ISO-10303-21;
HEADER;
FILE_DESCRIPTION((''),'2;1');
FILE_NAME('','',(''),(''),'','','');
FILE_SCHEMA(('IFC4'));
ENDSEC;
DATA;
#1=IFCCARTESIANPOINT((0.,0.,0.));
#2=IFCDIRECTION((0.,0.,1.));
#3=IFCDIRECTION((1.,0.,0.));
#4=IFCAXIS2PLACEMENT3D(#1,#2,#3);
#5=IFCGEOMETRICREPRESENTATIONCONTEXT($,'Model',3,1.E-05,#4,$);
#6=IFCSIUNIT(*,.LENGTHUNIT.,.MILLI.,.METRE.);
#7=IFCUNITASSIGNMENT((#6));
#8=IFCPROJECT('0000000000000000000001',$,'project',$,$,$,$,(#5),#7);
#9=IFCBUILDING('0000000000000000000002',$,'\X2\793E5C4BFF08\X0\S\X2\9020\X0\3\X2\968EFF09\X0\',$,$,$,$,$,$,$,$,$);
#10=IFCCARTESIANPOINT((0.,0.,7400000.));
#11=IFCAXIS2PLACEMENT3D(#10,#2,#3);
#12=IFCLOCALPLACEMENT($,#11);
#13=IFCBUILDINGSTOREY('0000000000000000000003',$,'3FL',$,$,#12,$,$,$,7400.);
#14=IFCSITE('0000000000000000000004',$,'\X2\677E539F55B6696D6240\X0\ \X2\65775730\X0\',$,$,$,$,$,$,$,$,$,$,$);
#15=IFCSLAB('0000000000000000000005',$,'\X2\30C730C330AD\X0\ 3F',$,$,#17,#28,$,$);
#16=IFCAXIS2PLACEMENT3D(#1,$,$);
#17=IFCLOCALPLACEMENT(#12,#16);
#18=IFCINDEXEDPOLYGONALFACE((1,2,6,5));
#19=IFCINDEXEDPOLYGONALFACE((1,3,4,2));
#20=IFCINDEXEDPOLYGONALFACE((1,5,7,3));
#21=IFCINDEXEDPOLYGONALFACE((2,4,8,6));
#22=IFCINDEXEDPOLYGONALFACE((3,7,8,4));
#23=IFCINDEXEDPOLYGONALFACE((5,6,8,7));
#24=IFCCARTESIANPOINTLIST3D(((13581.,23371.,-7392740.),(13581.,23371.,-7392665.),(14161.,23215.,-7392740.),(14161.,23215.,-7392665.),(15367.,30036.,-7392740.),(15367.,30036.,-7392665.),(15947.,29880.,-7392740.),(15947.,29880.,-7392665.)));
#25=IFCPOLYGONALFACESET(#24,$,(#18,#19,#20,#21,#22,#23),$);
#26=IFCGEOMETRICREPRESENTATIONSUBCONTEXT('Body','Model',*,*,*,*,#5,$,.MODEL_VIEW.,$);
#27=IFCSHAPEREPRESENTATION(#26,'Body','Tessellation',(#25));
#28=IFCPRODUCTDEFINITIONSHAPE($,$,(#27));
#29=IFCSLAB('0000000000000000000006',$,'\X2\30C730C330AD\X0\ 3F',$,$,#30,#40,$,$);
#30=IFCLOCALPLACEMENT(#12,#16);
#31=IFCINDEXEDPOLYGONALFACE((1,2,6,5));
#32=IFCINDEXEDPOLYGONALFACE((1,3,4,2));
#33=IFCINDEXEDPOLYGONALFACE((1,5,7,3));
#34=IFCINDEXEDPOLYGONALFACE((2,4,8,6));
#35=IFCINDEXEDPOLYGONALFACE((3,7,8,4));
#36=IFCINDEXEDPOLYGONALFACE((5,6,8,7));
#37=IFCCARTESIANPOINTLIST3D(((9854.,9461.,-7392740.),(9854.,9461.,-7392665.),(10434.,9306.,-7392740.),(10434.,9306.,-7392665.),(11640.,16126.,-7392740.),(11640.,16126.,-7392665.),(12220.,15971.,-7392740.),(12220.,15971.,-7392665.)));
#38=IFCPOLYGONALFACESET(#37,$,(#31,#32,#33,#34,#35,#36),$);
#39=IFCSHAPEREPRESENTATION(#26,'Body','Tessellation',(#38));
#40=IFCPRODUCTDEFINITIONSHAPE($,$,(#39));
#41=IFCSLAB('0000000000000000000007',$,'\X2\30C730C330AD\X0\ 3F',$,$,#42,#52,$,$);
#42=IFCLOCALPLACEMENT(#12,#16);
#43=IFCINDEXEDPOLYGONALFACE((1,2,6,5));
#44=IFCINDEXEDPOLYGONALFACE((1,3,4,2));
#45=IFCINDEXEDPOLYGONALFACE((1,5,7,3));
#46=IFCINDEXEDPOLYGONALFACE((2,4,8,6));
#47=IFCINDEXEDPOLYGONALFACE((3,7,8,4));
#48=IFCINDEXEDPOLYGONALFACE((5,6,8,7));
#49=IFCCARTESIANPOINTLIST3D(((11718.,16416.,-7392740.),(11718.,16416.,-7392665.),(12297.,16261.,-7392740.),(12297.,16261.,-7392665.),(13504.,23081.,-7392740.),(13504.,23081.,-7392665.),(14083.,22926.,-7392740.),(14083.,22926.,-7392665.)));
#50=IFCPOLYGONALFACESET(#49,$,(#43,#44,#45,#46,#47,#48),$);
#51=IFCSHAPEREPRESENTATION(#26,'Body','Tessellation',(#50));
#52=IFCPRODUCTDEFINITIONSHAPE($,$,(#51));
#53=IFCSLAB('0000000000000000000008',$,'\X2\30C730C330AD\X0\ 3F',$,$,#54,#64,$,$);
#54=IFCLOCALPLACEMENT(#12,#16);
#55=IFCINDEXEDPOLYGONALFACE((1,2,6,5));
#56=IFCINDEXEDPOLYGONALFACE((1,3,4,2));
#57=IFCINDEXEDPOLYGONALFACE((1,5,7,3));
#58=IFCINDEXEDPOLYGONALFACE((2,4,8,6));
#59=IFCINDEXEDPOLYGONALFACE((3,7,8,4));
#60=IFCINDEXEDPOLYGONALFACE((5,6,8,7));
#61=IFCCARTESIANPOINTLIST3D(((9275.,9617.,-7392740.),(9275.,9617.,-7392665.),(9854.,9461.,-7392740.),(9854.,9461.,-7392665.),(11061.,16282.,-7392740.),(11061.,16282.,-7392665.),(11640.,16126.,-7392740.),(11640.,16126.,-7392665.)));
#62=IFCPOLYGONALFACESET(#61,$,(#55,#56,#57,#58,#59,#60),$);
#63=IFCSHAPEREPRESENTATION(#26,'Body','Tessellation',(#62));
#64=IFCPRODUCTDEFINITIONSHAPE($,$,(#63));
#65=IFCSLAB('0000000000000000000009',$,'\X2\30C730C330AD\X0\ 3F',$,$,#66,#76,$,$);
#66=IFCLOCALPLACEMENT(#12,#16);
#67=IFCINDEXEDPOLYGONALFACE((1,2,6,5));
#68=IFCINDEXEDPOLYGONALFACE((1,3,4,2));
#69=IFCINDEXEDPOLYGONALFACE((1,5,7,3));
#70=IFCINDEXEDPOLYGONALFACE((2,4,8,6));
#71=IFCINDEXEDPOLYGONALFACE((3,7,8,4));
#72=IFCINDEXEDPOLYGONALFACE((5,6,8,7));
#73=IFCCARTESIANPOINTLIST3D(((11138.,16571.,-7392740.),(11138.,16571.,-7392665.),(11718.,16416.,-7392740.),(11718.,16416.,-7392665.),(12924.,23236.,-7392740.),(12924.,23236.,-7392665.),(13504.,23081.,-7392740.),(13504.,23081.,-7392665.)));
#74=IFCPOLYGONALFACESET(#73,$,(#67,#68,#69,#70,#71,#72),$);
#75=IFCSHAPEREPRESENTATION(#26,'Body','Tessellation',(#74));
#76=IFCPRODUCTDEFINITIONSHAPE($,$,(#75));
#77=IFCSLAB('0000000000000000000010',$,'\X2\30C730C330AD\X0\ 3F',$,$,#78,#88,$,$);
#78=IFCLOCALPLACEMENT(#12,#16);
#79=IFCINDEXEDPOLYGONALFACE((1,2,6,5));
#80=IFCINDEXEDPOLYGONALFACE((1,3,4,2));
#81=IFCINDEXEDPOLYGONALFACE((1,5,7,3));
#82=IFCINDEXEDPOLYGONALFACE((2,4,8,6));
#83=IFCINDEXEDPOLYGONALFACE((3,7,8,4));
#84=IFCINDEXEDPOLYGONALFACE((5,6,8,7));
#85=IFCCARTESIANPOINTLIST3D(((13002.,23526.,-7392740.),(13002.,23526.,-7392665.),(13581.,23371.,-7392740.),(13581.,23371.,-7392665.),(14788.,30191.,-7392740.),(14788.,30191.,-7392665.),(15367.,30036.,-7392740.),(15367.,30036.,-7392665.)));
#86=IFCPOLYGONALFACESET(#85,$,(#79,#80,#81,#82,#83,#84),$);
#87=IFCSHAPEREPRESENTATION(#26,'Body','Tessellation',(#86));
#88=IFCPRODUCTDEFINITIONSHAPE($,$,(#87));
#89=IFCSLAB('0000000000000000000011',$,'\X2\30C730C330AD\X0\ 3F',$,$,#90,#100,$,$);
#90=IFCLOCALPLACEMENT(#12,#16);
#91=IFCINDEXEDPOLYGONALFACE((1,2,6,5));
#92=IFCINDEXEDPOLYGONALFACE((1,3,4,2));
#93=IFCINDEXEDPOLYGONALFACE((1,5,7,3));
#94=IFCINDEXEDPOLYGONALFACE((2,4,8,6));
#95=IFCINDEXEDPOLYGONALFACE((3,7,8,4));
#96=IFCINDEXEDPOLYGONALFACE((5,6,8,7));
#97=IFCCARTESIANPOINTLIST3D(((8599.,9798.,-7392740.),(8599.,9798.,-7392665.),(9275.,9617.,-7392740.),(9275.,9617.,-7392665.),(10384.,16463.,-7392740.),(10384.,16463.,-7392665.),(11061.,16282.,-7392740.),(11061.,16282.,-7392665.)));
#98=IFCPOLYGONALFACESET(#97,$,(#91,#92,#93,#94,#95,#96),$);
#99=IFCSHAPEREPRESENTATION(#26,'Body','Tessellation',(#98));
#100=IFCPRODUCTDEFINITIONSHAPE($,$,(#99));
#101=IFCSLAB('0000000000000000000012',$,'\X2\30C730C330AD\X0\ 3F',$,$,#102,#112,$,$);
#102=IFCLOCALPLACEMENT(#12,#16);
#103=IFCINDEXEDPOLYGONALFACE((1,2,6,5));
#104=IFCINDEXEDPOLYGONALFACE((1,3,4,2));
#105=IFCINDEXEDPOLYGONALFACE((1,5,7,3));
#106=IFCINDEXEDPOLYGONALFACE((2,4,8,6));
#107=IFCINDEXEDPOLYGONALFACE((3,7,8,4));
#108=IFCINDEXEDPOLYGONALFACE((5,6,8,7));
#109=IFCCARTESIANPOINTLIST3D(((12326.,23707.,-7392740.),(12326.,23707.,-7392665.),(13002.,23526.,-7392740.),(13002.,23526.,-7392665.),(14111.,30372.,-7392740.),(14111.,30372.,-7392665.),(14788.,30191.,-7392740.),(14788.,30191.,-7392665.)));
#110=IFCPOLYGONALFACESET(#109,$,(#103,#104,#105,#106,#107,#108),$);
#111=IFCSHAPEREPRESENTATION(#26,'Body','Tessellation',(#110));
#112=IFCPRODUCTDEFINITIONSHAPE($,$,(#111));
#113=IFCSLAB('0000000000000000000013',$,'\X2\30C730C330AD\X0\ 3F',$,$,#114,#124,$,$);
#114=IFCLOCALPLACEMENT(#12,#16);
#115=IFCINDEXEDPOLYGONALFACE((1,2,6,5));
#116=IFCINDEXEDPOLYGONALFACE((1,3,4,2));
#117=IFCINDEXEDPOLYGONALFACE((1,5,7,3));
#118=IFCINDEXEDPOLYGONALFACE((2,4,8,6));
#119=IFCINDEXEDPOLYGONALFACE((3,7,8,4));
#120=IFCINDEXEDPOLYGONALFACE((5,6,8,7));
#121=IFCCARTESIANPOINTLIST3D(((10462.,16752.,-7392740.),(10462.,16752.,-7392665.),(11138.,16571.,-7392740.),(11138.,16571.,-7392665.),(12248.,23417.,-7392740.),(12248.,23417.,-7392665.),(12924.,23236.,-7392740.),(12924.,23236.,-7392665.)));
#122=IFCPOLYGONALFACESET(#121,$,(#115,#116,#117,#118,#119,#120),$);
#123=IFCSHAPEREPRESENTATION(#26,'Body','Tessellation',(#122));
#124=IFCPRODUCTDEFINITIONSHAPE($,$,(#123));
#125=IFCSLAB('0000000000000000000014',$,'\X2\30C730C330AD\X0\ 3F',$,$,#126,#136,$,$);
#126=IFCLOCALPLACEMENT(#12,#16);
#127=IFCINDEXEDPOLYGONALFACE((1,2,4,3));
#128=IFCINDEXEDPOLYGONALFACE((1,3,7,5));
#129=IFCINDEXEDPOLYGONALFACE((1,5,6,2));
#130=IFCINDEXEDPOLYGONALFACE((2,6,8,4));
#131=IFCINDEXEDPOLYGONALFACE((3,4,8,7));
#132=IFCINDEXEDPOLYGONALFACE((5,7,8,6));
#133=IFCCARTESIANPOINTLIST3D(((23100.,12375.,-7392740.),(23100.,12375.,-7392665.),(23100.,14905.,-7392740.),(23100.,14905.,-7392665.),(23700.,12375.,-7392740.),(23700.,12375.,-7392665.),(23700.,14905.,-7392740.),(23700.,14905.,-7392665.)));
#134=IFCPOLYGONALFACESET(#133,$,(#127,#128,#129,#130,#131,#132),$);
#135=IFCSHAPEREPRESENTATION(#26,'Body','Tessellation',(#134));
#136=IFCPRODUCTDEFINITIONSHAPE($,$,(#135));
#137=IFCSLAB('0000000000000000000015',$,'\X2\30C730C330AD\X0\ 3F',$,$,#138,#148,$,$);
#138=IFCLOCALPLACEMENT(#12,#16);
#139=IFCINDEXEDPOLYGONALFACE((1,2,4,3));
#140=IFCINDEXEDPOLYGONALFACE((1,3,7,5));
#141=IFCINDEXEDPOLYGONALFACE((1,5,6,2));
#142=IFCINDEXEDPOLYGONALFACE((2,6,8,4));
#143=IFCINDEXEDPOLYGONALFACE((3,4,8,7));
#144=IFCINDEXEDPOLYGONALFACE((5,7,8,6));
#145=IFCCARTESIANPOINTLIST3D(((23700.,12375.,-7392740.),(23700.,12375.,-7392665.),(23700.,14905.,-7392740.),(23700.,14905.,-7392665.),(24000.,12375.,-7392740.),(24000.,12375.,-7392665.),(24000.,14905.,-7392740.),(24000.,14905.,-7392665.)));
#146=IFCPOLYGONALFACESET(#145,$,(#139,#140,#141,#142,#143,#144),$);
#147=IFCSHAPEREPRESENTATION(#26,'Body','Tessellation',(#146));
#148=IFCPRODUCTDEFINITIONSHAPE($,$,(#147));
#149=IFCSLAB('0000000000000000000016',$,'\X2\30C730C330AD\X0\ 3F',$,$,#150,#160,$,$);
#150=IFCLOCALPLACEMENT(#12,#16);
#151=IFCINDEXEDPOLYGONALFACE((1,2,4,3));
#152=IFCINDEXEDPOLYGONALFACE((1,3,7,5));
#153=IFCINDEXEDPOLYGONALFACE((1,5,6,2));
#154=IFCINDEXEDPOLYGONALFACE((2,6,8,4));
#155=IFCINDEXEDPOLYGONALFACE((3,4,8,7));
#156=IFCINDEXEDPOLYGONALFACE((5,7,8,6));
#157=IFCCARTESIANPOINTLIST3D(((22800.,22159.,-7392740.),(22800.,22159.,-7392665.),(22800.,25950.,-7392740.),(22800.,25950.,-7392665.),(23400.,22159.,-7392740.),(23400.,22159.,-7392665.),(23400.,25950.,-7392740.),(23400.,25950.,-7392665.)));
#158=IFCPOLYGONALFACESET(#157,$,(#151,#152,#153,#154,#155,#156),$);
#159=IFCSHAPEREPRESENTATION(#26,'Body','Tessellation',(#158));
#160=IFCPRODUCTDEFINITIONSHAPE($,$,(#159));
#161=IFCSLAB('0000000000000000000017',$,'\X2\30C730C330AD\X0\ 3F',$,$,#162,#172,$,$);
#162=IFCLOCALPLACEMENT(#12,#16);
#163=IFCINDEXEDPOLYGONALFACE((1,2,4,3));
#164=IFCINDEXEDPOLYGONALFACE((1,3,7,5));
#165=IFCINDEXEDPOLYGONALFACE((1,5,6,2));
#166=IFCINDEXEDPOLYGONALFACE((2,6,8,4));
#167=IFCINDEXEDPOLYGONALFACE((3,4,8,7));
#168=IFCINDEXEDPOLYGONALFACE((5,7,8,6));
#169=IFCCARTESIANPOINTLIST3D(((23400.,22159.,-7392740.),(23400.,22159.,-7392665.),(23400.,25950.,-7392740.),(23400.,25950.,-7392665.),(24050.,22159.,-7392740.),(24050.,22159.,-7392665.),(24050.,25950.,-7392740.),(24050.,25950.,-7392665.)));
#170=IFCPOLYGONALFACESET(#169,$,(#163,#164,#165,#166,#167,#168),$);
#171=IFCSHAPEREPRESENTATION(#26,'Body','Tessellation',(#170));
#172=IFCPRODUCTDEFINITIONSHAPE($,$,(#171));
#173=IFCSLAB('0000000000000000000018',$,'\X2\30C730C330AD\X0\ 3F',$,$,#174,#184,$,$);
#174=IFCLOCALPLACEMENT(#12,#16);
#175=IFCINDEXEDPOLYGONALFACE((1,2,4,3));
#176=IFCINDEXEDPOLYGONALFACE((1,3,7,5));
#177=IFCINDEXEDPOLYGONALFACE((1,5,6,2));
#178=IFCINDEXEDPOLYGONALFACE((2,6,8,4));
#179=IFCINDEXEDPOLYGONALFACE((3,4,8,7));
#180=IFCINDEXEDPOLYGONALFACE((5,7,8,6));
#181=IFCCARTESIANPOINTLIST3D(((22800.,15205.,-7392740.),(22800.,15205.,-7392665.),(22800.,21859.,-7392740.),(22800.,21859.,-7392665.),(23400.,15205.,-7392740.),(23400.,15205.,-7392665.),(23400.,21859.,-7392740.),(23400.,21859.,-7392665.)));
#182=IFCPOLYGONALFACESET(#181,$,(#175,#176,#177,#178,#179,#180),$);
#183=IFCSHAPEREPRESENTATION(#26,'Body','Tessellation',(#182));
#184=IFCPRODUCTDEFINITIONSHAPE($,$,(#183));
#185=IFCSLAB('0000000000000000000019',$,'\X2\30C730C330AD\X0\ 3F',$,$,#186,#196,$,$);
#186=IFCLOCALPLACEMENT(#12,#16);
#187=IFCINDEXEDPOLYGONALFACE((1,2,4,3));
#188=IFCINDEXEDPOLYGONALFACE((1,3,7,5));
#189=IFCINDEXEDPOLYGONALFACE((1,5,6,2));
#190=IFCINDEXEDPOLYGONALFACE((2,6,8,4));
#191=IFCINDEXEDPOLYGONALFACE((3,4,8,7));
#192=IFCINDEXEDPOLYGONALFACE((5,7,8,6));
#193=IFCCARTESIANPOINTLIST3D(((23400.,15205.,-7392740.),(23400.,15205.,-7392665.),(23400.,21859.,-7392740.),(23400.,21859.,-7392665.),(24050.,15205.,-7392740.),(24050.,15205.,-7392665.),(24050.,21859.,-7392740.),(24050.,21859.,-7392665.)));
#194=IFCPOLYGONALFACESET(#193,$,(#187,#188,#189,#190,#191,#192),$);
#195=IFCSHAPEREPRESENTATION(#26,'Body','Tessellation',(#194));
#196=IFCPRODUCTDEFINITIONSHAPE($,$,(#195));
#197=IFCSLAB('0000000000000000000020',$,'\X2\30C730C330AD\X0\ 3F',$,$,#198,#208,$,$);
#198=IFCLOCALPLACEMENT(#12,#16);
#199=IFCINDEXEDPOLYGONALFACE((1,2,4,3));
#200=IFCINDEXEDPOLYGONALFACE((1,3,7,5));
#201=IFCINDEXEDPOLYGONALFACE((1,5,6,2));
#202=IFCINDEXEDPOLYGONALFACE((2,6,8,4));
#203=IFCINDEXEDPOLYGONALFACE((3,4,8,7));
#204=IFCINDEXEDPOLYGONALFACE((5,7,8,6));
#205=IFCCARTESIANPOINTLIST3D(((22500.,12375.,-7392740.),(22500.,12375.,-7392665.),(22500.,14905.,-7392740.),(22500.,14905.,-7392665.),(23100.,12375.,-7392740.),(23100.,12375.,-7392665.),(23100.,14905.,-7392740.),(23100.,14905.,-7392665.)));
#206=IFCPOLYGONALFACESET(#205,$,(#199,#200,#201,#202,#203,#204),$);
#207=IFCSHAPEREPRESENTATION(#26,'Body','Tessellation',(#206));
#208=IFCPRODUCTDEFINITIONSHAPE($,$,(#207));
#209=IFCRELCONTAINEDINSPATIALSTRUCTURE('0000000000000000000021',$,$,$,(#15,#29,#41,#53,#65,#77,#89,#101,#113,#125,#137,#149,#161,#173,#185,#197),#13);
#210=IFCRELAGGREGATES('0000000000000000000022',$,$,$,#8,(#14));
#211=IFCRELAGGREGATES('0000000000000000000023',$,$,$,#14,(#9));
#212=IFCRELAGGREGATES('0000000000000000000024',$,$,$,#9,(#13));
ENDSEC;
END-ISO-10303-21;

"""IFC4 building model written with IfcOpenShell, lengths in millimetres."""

from ifc_helpers import new_model, si_unit, frame, origin, origin_with_axes, place, context, subcontext, project, spatial, polyline, outline, extrude, element, save


model = new_model("IFC4")

# Units and contexts
model_context = context("Model", 3, precision=1e-05, world=origin_with_axes())
body_context = subcontext(model_context, "Body", "Model", "MODEL_VIEW")
ifc_project = project(units=[si_unit("LENGTHUNIT", "METRE", prefix="MILLI")], contexts=[model_context])

# Site, building, storey
site = spatial("IfcSite", under=ifc_project, Name="松原営業所 敷地")
building = spatial("IfcBuilding", under=site, Name="社屋（S造3階）")
storey_placement = place(None, frame((0.0, 0.0, 7400000.0), z_axis=(0.0, 0.0, 1.0), x_axis=(1.0, 0.0, 0.0)))
storey = spatial("IfcBuildingStorey", under=building, at=storey_placement, Name="3FL", Elevation=7400.0)

# Slabs
slab_1_placement = place(storey_placement, frame((0.0, 0.0, -7392740.0), z_axis=(0.0, 0.0, 1.0), x_axis=(1.0, 0.0, 0.0)))
element("IfcSlab", 1, at=slab_1_placement, inside=storey, Name="デッキ 3F", context=body_context, shape_type="SweptSolid", body=[
    extrude(outline(polyline([(14161.0, 23215.0), (15947.0, 29880.0), (15367.0, 30036.0), (13581.0, 23371.0), (14161.0, 23215.0)])), origin(), (0.0, 0.0, 1.0), 75.0),
])
slab_2_placement = place(storey_placement, frame((0.0, 0.0, -7392740.0), z_axis=(0.0, 0.0, 1.0), x_axis=(1.0, 0.0, 0.0)))
element("IfcSlab", 2, at=slab_2_placement, inside=storey, Name="デッキ 3F", context=body_context, shape_type="SweptSolid", body=[
    extrude(outline(polyline([(10434.0, 9306.0), (12220.0, 15971.0), (11640.0, 16126.0), (9854.0, 9461.0), (10434.0, 9306.0)])), origin(), (0.0, 0.0, 1.0), 75.0),
])
slab_3_placement = place(storey_placement, frame((0.0, 0.0, -7392740.0), z_axis=(0.0, 0.0, 1.0), x_axis=(1.0, 0.0, 0.0)))
element("IfcSlab", 3, at=slab_3_placement, inside=storey, Name="デッキ 3F", context=body_context, shape_type="SweptSolid", body=[
    extrude(outline(polyline([(12297.0, 16261.0), (14083.0, 22926.0), (13504.0, 23081.0), (11718.0, 16416.0), (12297.0, 16261.0)])), origin(), (0.0, 0.0, 1.0), 75.0),
])
slab_4_placement = place(storey_placement, frame((0.0, 0.0, -7392740.0), z_axis=(0.0, 0.0, 1.0), x_axis=(1.0, 0.0, 0.0)))
element("IfcSlab", 4, at=slab_4_placement, inside=storey, Name="デッキ 3F", context=body_context, shape_type="SweptSolid", body=[
    extrude(outline(polyline([(9854.0, 9461.0), (11640.0, 16126.0), (11061.0, 16282.0), (9275.0, 9617.0), (9854.0, 9461.0)])), origin(), (0.0, 0.0, 1.0), 75.0),
])
slab_5_placement = place(storey_placement, frame((0.0, 0.0, -7392740.0), z_axis=(0.0, 0.0, 1.0), x_axis=(1.0, 0.0, 0.0)))
element("IfcSlab", 5, at=slab_5_placement, inside=storey, Name="デッキ 3F", context=body_context, shape_type="SweptSolid", body=[
    extrude(outline(polyline([(11718.0, 16416.0), (13504.0, 23081.0), (12924.0, 23236.0), (11138.0, 16571.0), (11718.0, 16416.0)])), origin(), (0.0, 0.0, 1.0), 75.0),
])
slab_6_placement = place(storey_placement, frame((0.0, 0.0, -7392740.0), z_axis=(0.0, 0.0, 1.0), x_axis=(1.0, 0.0, 0.0)))
element("IfcSlab", 6, at=slab_6_placement, inside=storey, Name="デッキ 3F", context=body_context, shape_type="SweptSolid", body=[
    extrude(outline(polyline([(13581.0, 23371.0), (15367.0, 30036.0), (14788.0, 30191.0), (13002.0, 23526.0), (13581.0, 23371.0)])), origin(), (0.0, 0.0, 1.0), 75.0),
])
slab_7_placement = place(storey_placement, frame((0.0, 0.0, -7392740.0), z_axis=(0.0, 0.0, 1.0), x_axis=(1.0, 0.0, 0.0)))
element("IfcSlab", 7, at=slab_7_placement, inside=storey, Name="デッキ 3F", context=body_context, shape_type="SweptSolid", body=[
    extrude(outline(polyline([(9275.0, 9617.0), (11061.0, 16282.0), (10384.0, 16463.0), (8599.0, 9798.0), (9275.0, 9617.0)])), origin(), (0.0, 0.0, 1.0), 75.0),
])
slab_8_placement = place(storey_placement, frame((0.0, 0.0, -7392740.0), z_axis=(0.0, 0.0, 1.0), x_axis=(1.0, 0.0, 0.0)))
element("IfcSlab", 8, at=slab_8_placement, inside=storey, Name="デッキ 3F", context=body_context, shape_type="SweptSolid", body=[
    extrude(outline(polyline([(13002.0, 23526.0), (14788.0, 30191.0), (14111.0, 30372.0), (12326.0, 23707.0), (13002.0, 23526.0)])), origin(), (0.0, 0.0, 1.0), 75.0),
])
slab_9_placement = place(storey_placement, frame((0.0, 0.0, -7392740.0), z_axis=(0.0, 0.0, 1.0), x_axis=(1.0, 0.0, 0.0)))
element("IfcSlab", 9, at=slab_9_placement, inside=storey, Name="デッキ 3F", context=body_context, shape_type="SweptSolid", body=[
    extrude(outline(polyline([(11138.0, 16571.0), (12924.0, 23236.0), (12248.0, 23417.0), (10462.0, 16752.0), (11138.0, 16571.0)])), origin(), (0.0, 0.0, 1.0), 75.0),
])
slab_10_placement = place(storey_placement, frame((0.0, 0.0, -7392740.0), z_axis=(0.0, 0.0, 1.0), x_axis=(1.0, 0.0, 0.0)))
element("IfcSlab", 10, at=slab_10_placement, inside=storey, Name="デッキ 3F", context=body_context, shape_type="SweptSolid", body=[
    extrude(outline(polyline([(23700.0, 12375.0), (23700.0, 14905.0), (23100.0, 14905.0), (23100.0, 12375.0), (23700.0, 12375.0)])), origin(), (0.0, 0.0, 1.0), 75.0),
])
slab_11_placement = place(storey_placement, frame((0.0, 0.0, -7392740.0), z_axis=(0.0, 0.0, 1.0), x_axis=(1.0, 0.0, 0.0)))
element("IfcSlab", 11, at=slab_11_placement, inside=storey, Name="デッキ 3F", context=body_context, shape_type="SweptSolid", body=[
    extrude(outline(polyline([(23700.0, 12375.0), (23700.0, 14905.0), (24000.0, 14905.0), (24000.0, 12375.0), (23700.0, 12375.0)])), origin(), (0.0, 0.0, 1.0), 75.0),
])
slab_12_placement = place(storey_placement, frame((0.0, 0.0, -7392740.0), z_axis=(0.0, 0.0, 1.0), x_axis=(1.0, 0.0, 0.0)))
element("IfcSlab", 12, at=slab_12_placement, inside=storey, Name="デッキ 3F", context=body_context, shape_type="SweptSolid", body=[
    extrude(outline(polyline([(23400.0, 22159.0), (23400.0, 25950.0), (22800.0, 25950.0), (22800.0, 22159.0), (23400.0, 22159.0)])), origin(), (0.0, 0.0, 1.0), 75.0),
])
slab_13_placement = place(storey_placement, frame((0.0, 0.0, -7392740.0), z_axis=(0.0, 0.0, 1.0), x_axis=(1.0, 0.0, 0.0)))
element("IfcSlab", 13, at=slab_13_placement, inside=storey, Name="デッキ 3F", context=body_context, shape_type="SweptSolid", body=[
    extrude(outline(polyline([(23400.0, 22159.0), (23400.0, 25950.0), (24050.0, 25950.0), (24050.0, 22159.0), (23400.0, 22159.0)])), origin(), (0.0, 0.0, 1.0), 75.0),
])
slab_14_placement = place(storey_placement, frame((0.0, 0.0, -7392740.0), z_axis=(0.0, 0.0, 1.0), x_axis=(1.0, 0.0, 0.0)))
element("IfcSlab", 14, at=slab_14_placement, inside=storey, Name="デッキ 3F", context=body_context, shape_type="SweptSolid", body=[
    extrude(outline(polyline([(23400.0, 15205.0), (23400.0, 21859.0), (22800.0, 21859.0), (22800.0, 15205.0), (23400.0, 15205.0)])), origin(), (0.0, 0.0, 1.0), 75.0),
])
slab_15_placement = place(storey_placement, frame((0.0, 0.0, -7392740.0), z_axis=(0.0, 0.0, 1.0), x_axis=(1.0, 0.0, 0.0)))
element("IfcSlab", 15, at=slab_15_placement, inside=storey, Name="デッキ 3F", context=body_context, shape_type="SweptSolid", body=[
    extrude(outline(polyline([(23400.0, 15205.0), (23400.0, 21859.0), (24050.0, 21859.0), (24050.0, 15205.0), (23400.0, 15205.0)])), origin(), (0.0, 0.0, 1.0), 75.0),
])
slab_16_placement = place(storey_placement, frame((0.0, 0.0, -7392740.0), z_axis=(0.0, 0.0, 1.0), x_axis=(1.0, 0.0, 0.0)))
element("IfcSlab", 16, at=slab_16_placement, inside=storey, Name="デッキ 3F", context=body_context, shape_type="SweptSolid", body=[
    extrude(outline(polyline([(23100.0, 12375.0), (23100.0, 14905.0), (22500.0, 14905.0), (22500.0, 12375.0), (23100.0, 12375.0)])), origin(), (0.0, 0.0, 1.0), 75.0),
])

save(model, "model.ifc")
